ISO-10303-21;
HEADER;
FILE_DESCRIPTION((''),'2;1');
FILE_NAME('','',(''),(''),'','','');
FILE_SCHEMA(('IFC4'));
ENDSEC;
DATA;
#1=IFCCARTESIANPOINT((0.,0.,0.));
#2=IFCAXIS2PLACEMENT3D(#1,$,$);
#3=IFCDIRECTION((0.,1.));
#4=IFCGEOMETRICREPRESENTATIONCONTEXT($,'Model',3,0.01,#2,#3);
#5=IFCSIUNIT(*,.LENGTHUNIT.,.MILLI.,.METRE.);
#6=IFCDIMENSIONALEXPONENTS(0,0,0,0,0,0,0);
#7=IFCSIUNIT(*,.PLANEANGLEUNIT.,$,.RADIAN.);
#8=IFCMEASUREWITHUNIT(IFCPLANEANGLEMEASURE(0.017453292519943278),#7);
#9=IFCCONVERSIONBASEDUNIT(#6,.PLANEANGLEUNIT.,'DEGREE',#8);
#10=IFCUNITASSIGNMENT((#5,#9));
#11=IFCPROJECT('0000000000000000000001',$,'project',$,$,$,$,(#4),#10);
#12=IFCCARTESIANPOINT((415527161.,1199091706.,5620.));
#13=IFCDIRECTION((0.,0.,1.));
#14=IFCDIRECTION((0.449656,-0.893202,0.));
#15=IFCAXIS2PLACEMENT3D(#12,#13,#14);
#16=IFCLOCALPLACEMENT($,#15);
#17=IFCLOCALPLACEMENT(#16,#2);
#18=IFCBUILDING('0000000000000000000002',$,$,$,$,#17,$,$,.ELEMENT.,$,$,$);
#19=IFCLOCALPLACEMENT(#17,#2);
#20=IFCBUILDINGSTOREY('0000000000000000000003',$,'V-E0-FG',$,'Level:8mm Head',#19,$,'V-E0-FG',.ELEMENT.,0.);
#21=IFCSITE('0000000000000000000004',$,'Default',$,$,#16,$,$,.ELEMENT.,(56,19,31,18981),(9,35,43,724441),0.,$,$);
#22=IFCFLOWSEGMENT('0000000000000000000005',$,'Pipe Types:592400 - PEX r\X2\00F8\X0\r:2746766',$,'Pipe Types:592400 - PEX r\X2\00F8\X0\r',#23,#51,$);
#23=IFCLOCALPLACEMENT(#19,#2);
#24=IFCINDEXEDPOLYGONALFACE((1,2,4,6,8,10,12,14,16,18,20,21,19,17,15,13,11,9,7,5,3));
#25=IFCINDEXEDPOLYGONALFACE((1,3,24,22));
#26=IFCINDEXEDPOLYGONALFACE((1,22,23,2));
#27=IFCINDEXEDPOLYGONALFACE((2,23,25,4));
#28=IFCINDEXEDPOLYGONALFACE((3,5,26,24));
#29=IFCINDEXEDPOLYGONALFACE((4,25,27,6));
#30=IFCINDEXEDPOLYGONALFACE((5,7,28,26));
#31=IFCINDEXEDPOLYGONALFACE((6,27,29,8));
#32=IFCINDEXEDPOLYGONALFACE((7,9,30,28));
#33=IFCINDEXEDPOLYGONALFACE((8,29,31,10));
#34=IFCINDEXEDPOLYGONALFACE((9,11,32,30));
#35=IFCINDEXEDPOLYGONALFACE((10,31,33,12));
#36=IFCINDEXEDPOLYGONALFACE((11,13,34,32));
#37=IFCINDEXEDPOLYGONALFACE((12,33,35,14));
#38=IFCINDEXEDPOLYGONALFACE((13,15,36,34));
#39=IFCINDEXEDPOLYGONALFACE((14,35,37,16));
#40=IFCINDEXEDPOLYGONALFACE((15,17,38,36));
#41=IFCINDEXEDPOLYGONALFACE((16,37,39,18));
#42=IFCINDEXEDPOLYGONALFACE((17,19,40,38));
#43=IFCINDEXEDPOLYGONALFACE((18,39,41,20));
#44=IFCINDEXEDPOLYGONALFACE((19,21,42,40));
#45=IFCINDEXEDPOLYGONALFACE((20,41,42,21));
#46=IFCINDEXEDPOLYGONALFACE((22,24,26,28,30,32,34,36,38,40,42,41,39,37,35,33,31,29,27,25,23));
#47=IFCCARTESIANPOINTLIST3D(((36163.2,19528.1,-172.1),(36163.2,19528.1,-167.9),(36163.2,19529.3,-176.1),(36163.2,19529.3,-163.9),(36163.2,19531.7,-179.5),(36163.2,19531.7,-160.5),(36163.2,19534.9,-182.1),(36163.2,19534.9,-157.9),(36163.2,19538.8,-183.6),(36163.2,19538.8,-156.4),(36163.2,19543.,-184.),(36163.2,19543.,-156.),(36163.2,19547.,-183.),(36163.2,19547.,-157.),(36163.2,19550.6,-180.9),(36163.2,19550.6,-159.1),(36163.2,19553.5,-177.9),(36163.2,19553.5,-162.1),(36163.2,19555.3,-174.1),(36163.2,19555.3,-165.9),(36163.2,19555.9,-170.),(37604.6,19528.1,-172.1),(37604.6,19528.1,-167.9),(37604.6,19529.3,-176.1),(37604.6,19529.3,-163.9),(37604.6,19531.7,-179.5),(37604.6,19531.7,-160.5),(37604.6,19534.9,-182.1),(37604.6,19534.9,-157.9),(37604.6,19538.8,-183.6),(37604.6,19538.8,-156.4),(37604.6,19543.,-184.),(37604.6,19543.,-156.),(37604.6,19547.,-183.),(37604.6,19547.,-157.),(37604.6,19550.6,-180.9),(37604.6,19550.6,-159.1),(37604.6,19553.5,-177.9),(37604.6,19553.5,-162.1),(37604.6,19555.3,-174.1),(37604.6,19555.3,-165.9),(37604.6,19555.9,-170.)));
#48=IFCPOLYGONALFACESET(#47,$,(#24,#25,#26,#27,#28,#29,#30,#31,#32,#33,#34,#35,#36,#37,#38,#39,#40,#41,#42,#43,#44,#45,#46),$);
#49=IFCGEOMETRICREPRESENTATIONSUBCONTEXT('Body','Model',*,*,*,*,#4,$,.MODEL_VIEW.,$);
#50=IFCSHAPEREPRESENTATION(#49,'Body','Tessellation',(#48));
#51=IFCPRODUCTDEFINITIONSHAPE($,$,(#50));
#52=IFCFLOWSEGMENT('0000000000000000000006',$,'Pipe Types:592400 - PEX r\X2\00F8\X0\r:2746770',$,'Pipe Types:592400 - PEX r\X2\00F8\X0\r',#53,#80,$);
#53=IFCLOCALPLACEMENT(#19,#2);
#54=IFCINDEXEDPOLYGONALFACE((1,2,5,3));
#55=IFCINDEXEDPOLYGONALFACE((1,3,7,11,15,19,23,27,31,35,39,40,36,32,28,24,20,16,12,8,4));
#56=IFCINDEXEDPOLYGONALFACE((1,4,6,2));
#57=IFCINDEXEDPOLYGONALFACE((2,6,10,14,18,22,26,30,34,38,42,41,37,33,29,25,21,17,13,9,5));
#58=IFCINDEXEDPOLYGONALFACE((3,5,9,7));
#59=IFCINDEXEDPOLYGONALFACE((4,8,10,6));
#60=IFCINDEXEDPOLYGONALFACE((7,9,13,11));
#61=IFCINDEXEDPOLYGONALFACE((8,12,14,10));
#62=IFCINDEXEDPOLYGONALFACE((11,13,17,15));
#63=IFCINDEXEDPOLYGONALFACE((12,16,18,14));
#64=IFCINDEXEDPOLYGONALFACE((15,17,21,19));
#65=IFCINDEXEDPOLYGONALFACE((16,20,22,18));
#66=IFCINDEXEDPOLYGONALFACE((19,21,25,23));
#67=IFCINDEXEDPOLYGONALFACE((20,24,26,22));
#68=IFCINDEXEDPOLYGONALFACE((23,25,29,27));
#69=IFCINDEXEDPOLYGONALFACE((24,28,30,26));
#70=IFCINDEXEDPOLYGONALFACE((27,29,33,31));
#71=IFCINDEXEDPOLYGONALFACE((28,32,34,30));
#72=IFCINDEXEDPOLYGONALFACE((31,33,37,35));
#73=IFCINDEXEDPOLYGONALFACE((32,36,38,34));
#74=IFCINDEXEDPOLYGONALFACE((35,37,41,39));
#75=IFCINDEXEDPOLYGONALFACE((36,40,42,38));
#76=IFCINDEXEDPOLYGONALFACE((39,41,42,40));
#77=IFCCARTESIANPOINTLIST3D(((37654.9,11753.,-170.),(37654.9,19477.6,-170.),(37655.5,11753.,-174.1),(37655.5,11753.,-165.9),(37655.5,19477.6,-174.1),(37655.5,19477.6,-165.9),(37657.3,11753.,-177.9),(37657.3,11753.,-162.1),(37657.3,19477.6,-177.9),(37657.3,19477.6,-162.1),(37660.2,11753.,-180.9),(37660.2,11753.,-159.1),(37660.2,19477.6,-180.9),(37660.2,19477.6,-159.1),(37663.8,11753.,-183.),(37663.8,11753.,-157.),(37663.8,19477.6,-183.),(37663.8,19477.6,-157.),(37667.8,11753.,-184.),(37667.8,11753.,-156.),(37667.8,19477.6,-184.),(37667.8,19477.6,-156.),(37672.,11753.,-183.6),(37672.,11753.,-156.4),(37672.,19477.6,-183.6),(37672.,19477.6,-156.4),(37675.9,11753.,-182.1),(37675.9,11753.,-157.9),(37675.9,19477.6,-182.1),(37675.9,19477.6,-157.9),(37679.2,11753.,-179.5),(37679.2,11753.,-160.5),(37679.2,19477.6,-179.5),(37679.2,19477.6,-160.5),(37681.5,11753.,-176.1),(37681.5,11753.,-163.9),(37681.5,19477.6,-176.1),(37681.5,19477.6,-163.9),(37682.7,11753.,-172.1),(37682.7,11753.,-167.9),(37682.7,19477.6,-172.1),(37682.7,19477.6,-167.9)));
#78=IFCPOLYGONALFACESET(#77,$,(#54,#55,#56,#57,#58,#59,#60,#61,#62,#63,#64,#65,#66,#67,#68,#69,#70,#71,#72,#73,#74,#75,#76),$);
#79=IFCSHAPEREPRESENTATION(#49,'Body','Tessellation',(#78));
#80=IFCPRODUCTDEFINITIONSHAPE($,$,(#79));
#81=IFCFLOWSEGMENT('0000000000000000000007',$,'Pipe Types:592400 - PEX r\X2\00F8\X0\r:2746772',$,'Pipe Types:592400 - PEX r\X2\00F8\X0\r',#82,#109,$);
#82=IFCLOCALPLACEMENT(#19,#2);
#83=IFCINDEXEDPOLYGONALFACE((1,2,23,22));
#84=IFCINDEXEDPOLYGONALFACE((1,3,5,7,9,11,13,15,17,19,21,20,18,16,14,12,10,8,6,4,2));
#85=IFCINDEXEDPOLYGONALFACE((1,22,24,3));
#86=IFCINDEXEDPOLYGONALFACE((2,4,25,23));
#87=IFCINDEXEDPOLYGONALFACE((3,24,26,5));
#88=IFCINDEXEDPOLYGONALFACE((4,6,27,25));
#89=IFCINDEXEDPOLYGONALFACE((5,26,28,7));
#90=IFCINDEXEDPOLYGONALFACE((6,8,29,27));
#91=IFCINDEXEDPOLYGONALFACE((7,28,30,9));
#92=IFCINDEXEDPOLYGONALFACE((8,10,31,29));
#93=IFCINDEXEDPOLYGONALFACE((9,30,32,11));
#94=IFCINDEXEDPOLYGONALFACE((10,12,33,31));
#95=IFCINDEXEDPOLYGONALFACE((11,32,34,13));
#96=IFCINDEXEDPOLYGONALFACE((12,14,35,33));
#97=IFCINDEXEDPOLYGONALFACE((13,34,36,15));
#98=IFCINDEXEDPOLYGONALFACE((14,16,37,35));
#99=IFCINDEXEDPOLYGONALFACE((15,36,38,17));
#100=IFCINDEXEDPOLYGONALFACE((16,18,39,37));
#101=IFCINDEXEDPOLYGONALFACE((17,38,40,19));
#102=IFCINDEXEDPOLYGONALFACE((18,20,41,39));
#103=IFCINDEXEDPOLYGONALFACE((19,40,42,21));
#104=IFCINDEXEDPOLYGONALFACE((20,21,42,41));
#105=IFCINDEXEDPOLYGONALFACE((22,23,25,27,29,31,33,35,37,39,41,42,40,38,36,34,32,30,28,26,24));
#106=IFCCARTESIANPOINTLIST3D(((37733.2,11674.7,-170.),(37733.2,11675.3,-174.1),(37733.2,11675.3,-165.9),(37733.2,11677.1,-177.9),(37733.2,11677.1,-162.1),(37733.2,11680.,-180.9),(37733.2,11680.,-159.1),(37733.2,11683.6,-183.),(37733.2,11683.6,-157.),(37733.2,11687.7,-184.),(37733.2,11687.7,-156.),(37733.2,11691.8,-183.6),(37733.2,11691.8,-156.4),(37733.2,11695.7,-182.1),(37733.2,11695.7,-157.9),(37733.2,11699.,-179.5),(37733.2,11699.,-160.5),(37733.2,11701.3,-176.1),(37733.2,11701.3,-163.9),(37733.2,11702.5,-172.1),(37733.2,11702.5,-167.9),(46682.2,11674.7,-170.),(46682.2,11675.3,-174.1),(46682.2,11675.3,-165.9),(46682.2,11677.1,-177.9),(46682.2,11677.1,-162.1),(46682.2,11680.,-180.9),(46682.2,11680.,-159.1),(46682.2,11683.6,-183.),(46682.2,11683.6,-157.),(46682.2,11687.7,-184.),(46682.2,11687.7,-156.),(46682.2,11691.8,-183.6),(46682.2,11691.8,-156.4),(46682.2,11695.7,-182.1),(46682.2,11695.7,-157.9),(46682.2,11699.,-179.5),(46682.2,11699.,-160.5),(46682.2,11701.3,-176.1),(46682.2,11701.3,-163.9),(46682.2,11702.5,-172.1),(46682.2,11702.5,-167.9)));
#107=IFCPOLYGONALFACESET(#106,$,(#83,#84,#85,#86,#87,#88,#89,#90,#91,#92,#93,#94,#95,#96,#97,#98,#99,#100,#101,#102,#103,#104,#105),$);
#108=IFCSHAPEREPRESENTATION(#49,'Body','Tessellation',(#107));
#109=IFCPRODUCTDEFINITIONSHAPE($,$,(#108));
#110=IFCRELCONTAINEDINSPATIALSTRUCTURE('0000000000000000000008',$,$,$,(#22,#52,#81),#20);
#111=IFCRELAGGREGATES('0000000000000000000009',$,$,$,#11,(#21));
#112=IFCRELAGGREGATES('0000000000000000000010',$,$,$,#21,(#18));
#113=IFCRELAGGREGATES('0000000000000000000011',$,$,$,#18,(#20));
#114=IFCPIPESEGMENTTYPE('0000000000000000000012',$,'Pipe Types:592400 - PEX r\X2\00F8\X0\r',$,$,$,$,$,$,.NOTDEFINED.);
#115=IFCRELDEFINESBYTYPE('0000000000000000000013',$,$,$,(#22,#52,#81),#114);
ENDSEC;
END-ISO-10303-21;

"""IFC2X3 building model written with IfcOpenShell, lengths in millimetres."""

from ifc_helpers import new_model, entity, si_unit, converted_unit, direction, frame, frame_2d, origin, origin_2d_with_axis, place, context, subcontext, project, spatial, circle, extrude, type_object, element, save


model = new_model("IFC2X3")

# Units and contexts
model_context = context("Model", 3, precision=0.01, world=origin(), true_north=direction((0.0, 1.0)))
body_context = subcontext(model_context, "Body", "Model", "MODEL_VIEW")
ifc_project = project(units=[si_unit("LENGTHUNIT", "METRE", prefix="MILLI"), converted_unit("PLANEANGLEUNIT", "DEGREE", entity("IfcPlaneAngleMeasure", 0.017453292519943278), si_unit("PLANEANGLEUNIT", "RADIAN"), dimensions=[0, 0, 0, 0, 0, 0, 0])], contexts=[model_context])

# Site, building, storey
site_placement = place(None, frame((415527161.0, 1199091706.0, 5620.0), z_axis=(0.0, 0.0, 1.0), x_axis=(0.449656, -0.893202, 0.0)))
site = spatial("IfcSite", under=ifc_project, at=site_placement, Name="Default", CompositionType="ELEMENT", RefLatitude=(56, 19, 31, 18981), RefLongitude=(9, 35, 43, 724441), RefElevation=0.0)
building_placement = place(site_placement, origin())
building = spatial("IfcBuilding", under=site, at=building_placement, CompositionType="ELEMENT")
storey_placement = place(building_placement, origin())
storey = spatial("IfcBuildingStorey", under=building, at=storey_placement, Name="V-E0-FG", ObjectType="Level:8mm Head", LongName="V-E0-FG", CompositionType="ELEMENT", Elevation=0.0)

# Flow segments
pipe_segment_type_1 = type_object("IfcPipeSegmentType", Name="Pipe Types:592400 - PEX rør", PredefinedType="NOTDEFINED")
flow_segment_1_placement = place(storey_placement, origin())
element("IfcFlowSegment", 1, at=flow_segment_1_placement, inside=storey, type_object=pipe_segment_type_1, Name="Pipe Types:592400 - PEX rør:2746766", ObjectType="Pipe Types:592400 - PEX rør", context=body_context, shape_type="SweptSolid", body=[
    extrude(circle(Radius=14.0, at=origin_2d_with_axis()), frame((36163.2, 19541.9, -170.0), z_axis=(1.0, 0.0, 0.0), x_axis=(0.0, 1.0, 0.0)), (0.0, 0.0, 1.0), 1441.4),
])
flow_segment_2_placement = place(storey_placement, origin())
element("IfcFlowSegment", 2, at=flow_segment_2_placement, inside=storey, type_object=pipe_segment_type_1, Name="Pipe Types:592400 - PEX rør:2746770", ObjectType="Pipe Types:592400 - PEX rør", context=body_context, shape_type="SweptSolid", body=[
    extrude(circle(Radius=14.0, at=frame_2d((0.0, 0.0), x_axis=(1.0, 0.0))), frame((37668.9, 11753.0, -170.0), z_axis=(0.0, 1.0, 0.0), x_axis=(-1.0, 0.0, 0.0)), (0.0, 0.0, 1.0), 7724.7),
])
flow_segment_3_placement = place(storey_placement, origin())
element("IfcFlowSegment", 3, at=flow_segment_3_placement, inside=storey, type_object=pipe_segment_type_1, Name="Pipe Types:592400 - PEX rør:2746772", ObjectType="Pipe Types:592400 - PEX rør", context=body_context, shape_type="SweptSolid", body=[
    extrude(circle(Radius=14.0, at=origin_2d_with_axis()), frame((37733.2, 11688.7, -170.0), z_axis=(1.0, 0.0, 0.0), x_axis=(0.0, -1.0, 0.0)), (0.0, 0.0, 1.0), 8949.0),
])

save(model, "model.ifc")
